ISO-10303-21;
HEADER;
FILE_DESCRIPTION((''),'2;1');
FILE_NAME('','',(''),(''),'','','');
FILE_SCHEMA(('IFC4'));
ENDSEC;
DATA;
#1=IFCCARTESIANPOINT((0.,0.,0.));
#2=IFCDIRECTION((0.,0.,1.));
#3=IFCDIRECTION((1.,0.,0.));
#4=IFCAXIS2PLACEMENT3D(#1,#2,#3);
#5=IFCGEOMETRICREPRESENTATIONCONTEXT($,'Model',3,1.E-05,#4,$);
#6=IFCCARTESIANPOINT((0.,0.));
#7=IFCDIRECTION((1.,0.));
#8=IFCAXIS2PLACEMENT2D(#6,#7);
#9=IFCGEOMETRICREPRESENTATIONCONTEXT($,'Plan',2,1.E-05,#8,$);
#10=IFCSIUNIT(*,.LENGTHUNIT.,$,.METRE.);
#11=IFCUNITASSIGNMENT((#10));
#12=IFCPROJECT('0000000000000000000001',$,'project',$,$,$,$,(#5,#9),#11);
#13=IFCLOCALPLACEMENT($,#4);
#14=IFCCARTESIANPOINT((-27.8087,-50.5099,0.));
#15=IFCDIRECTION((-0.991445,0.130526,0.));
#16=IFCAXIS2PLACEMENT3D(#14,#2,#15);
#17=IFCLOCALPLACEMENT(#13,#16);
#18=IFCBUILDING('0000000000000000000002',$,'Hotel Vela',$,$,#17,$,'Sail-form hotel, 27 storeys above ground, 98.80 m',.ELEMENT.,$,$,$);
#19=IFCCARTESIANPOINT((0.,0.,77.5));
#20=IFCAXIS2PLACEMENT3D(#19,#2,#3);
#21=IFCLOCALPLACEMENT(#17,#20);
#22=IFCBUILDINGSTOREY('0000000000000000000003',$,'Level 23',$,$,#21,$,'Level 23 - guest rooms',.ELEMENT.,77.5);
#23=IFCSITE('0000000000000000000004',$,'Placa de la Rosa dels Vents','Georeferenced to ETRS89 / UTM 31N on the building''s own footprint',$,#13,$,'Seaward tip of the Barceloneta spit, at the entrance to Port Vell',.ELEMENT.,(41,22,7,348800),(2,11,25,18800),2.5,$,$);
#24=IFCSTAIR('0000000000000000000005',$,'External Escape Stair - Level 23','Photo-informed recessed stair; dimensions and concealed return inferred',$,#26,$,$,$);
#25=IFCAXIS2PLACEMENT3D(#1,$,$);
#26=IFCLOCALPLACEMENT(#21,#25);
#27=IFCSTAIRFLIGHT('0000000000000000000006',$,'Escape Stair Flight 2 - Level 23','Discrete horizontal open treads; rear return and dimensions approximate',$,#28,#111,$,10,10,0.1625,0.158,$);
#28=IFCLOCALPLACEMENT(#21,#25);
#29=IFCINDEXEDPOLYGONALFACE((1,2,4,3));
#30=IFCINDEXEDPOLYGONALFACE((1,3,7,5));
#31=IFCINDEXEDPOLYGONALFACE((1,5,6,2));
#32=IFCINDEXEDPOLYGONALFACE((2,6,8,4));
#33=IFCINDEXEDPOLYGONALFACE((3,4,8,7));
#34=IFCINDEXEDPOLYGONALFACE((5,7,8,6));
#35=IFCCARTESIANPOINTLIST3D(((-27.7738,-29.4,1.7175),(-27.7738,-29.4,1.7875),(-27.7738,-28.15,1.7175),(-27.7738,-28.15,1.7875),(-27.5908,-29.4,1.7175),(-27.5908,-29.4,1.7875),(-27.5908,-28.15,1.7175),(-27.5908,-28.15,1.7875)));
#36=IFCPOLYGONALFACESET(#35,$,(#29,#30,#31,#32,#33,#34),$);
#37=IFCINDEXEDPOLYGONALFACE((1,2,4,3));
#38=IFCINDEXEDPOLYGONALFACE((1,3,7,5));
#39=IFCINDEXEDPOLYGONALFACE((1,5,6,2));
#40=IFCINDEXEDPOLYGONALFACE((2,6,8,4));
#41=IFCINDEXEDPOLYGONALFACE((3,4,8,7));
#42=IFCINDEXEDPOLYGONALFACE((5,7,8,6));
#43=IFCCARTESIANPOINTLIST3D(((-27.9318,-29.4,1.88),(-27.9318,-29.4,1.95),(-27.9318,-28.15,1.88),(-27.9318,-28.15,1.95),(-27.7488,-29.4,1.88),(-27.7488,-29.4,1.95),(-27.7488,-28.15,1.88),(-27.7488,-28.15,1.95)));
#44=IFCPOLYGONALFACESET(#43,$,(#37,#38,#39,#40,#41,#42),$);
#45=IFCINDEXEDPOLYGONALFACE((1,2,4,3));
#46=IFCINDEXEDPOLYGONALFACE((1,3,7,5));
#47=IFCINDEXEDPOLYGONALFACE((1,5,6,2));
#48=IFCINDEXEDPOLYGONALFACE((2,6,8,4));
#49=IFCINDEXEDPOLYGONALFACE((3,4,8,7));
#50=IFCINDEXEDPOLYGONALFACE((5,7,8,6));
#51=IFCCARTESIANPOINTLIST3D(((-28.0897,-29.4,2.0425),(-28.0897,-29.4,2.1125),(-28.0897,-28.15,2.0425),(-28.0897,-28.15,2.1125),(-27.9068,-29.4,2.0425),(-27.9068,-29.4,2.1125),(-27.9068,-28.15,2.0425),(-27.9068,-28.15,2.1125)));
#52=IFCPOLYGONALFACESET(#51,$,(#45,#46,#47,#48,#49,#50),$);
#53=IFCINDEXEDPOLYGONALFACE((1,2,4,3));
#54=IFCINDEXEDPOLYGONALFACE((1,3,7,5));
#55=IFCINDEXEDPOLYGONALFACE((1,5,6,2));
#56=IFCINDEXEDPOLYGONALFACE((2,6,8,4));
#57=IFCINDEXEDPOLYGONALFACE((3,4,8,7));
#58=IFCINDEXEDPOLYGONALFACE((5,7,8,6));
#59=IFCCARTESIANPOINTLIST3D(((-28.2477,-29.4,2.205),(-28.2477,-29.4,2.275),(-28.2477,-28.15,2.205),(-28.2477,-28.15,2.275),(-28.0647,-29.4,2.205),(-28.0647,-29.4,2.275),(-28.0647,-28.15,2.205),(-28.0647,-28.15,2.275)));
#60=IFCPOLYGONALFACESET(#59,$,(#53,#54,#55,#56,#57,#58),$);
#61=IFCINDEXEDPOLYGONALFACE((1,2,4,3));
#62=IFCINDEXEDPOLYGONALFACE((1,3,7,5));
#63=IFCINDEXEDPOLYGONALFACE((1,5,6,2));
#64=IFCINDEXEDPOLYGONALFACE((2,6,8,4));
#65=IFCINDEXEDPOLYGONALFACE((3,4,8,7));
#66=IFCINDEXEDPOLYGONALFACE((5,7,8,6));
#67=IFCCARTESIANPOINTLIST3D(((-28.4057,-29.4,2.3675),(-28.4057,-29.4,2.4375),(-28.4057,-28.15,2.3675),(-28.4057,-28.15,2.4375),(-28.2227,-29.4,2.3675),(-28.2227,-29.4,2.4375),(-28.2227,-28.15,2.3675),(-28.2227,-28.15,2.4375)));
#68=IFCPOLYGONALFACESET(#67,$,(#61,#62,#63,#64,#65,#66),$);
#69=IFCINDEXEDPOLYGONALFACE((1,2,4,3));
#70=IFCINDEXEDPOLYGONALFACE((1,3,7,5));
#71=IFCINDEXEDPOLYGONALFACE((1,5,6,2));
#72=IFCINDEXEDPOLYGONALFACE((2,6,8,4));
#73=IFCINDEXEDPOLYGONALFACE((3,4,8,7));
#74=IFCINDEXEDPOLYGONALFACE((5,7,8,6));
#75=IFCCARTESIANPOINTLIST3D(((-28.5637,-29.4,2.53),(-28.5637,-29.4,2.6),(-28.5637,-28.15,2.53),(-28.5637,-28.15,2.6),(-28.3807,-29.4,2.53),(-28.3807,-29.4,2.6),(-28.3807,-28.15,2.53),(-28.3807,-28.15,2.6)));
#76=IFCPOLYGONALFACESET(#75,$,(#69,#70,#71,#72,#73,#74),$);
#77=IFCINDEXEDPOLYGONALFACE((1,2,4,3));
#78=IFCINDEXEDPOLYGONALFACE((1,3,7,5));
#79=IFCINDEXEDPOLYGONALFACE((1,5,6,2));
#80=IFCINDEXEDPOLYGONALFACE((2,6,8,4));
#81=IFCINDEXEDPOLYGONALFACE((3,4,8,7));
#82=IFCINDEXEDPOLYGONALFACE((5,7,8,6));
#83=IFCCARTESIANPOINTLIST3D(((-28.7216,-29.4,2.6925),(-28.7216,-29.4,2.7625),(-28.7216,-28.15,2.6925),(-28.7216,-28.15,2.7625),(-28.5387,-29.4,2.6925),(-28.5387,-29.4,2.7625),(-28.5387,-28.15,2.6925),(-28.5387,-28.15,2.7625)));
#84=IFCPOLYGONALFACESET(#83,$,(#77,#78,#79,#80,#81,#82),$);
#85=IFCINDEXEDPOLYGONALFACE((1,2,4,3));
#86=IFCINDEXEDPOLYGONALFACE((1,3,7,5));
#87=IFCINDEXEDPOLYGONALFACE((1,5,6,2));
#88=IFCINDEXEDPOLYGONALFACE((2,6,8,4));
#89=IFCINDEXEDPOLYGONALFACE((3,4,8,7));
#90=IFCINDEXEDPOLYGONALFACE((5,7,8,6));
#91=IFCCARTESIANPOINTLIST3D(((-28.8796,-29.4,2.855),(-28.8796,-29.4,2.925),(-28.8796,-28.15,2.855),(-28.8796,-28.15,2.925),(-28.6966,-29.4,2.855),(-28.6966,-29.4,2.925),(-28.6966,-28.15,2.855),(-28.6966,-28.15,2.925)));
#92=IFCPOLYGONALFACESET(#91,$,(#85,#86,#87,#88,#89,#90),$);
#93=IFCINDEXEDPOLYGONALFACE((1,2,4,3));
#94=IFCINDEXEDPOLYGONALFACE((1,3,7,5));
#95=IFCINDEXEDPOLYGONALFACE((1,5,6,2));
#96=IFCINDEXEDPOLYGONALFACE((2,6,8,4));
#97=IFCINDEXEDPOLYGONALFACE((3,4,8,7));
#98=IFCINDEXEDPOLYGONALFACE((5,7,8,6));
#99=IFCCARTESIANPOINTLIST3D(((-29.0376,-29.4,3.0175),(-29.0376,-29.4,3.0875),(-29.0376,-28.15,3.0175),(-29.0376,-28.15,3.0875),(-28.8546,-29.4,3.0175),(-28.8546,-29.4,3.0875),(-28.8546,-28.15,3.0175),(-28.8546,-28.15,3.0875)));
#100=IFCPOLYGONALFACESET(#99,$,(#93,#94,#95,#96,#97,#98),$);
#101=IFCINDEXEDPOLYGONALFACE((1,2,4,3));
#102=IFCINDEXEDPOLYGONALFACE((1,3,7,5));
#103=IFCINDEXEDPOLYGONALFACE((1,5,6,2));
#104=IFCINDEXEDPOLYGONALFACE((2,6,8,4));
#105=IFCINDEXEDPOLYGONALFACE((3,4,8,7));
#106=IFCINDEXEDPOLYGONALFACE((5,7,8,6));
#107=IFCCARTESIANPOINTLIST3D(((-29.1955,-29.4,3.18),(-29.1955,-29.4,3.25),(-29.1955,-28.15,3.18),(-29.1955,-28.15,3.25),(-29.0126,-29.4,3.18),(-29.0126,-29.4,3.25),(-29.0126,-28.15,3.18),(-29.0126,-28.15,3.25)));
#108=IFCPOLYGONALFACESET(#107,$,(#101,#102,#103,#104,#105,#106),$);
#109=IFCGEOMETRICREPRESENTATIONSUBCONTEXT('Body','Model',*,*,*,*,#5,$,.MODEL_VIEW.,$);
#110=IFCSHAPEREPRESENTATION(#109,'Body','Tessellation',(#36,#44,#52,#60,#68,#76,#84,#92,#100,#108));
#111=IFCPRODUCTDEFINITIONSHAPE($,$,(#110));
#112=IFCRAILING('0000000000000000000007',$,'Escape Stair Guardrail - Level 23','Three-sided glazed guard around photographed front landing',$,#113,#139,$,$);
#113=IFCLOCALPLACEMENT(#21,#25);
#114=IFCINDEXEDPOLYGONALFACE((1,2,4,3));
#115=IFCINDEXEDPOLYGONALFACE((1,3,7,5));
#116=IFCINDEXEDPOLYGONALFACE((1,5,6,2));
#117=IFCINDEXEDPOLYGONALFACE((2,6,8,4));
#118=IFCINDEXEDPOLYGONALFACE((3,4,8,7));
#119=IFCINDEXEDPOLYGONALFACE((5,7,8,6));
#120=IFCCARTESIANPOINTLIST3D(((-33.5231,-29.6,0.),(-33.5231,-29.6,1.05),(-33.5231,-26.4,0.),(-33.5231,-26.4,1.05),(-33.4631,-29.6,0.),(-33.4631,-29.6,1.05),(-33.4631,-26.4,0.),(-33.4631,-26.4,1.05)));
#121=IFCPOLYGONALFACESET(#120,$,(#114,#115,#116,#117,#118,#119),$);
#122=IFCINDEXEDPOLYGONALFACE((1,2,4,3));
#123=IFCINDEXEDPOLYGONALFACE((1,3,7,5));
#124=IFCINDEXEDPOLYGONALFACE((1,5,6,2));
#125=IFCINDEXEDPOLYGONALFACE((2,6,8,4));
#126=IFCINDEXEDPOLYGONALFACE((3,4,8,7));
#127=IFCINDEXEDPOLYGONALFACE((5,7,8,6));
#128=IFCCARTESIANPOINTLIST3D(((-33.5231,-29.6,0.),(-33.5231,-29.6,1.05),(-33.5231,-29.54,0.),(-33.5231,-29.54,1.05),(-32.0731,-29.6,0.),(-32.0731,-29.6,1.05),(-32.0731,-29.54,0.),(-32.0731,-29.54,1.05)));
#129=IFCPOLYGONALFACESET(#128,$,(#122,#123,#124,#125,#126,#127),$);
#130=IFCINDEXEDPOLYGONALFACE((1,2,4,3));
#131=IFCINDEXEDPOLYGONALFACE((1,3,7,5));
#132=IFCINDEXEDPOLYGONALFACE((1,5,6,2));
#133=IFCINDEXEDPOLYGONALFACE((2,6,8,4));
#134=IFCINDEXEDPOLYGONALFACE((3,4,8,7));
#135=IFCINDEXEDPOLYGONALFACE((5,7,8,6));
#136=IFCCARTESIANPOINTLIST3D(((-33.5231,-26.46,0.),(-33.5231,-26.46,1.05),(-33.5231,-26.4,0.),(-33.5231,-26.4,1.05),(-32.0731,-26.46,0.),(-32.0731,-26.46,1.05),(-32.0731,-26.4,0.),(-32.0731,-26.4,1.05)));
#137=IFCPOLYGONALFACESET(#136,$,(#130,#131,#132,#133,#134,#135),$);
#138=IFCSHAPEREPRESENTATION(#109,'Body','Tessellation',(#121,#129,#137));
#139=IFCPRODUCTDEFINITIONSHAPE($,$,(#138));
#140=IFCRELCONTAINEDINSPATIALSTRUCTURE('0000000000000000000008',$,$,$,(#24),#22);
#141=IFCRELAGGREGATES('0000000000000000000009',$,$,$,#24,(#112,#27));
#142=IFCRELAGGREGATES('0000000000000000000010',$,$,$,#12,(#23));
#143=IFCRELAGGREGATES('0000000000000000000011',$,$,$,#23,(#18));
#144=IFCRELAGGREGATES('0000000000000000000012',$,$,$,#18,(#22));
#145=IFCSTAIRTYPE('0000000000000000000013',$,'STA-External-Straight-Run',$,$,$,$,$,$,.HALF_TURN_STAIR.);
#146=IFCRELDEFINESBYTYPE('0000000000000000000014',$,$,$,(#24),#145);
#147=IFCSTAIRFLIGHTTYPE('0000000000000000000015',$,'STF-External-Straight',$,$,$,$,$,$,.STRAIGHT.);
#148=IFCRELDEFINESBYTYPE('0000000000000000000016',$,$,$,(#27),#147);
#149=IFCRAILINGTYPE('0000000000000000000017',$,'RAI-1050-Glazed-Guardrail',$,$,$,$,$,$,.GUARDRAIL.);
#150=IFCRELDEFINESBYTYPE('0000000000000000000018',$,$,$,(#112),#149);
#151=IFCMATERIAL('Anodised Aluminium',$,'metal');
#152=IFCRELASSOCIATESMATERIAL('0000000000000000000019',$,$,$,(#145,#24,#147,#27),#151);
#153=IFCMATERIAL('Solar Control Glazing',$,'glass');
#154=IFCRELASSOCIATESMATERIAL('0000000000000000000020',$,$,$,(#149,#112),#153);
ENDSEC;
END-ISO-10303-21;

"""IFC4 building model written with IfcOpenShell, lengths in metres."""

from ifc_helpers import new_model, si_unit, frame, origin_with_axes, origin_2d_with_axis, place, context, subcontext, project, spatial, line, indexed_curve, outline, extrude, material, type_object, element, aggregate, save


model = new_model("IFC4")

# Units and contexts
model_context = context("Model", 3, precision=1e-05, world=origin_with_axes())
plan_context = context("Plan", 2, precision=1e-05, world=origin_2d_with_axis())
body_context = subcontext(model_context, "Body", "Model", "MODEL_VIEW")
ifc_project = project(units=[si_unit("LENGTHUNIT", "METRE")], contexts=[model_context, plan_context])

# Site, building, storey
site_placement = place(None, origin_with_axes())
site = spatial("IfcSite", under=ifc_project, at=site_placement, Name="Placa de la Rosa dels Vents", Description="Georeferenced to ETRS89 / UTM 31N on the building's own footprint", LongName="Seaward tip of the Barceloneta spit, at the entrance to Port Vell", CompositionType="ELEMENT", RefLatitude=(41, 22, 7, 348800), RefLongitude=(2, 11, 25, 18800), RefElevation=2.5)
building_placement = place(site_placement, frame((-27.8087, -50.5099, 0.0), z_axis=(0.0, 0.0, 1.0), x_axis=(-0.991445, 0.130526, 0.0)))
building = spatial("IfcBuilding", under=site, at=building_placement, Name="Hotel Vela", LongName="Sail-form hotel, 27 storeys above ground, 98.80 m", CompositionType="ELEMENT")
storey_placement = place(building_placement, frame((0.0, 0.0, 77.5), z_axis=(0.0, 0.0, 1.0), x_axis=(1.0, 0.0, 0.0)))
storey = spatial("IfcBuildingStorey", under=building, at=storey_placement, Name="Level 23", LongName="Level 23 - guest rooms", CompositionType="ELEMENT", Elevation=77.5)

# Stair
ifc_material_1 = material(Name="Anodised Aluminium", Category="metal")
stair_type = type_object("IfcStairType", Name="STA-External-Straight-Run", PredefinedType="HALF_TURN_STAIR", material=ifc_material_1)
stair_placement = place(storey_placement, frame((0.0, 0.0, -77.5), z_axis=(0.0, 0.0, 1.0), x_axis=(1.0, 0.0, 0.0)))
stair = element("IfcStair", 1, at=stair_placement, inside=storey, type_object=stair_type, material=ifc_material_1, Name="External Escape Stair - Level 23", Description="Photo-informed recessed stair; dimensions and concealed return inferred")

# Stair flight
stair_flight_type = type_object("IfcStairFlightType", Name="STF-External-Straight", PredefinedType="STRAIGHT", material=ifc_material_1)
stair_flight_1_placement = place(stair_placement, origin_with_axes())
stair_flight_1 = element("IfcStairFlight", 2, at=stair_flight_1_placement, type_object=stair_flight_type, material=ifc_material_1, Name="Escape Stair Flight 2 - Level 23", Description="Discrete horizontal open treads; rear return and dimensions approximate", NumberOfRisers=10, NumberOfTreads=10, RiserHeight=0.1625, TreadLength=0.158, context=body_context, shape_type="SweptSolid", body=[
    extrude(outline(indexed_curve([(0.0, 0.0), (0.183, 0.0), (0.183, 1.25), (0.0, 1.25)], segments=[line(1, 2, 3, 4, 1)])), frame((-27.7738, -29.4, 79.2175), z_axis=(0.0, 0.0, 1.0), x_axis=(1.0, 0.0, 0.0)), (0.0, 0.0, 1.0), 0.07),
    extrude(outline(indexed_curve([(0.0, 0.0), (0.183, 0.0), (0.183, 1.25), (0.0, 1.25)], segments=[line(1, 2, 3, 4, 1)])), frame((-27.9318, -29.4, 79.38), z_axis=(0.0, 0.0, 1.0), x_axis=(1.0, 0.0, 0.0)), (0.0, 0.0, 1.0), 0.07),
    extrude(outline(indexed_curve([(0.0, 0.0), (0.183, 0.0), (0.183, 1.25), (0.0, 1.25)], segments=[line(1, 2, 3, 4, 1)])), frame((-28.0897, -29.4, 79.5425), z_axis=(0.0, 0.0, 1.0), x_axis=(1.0, 0.0, 0.0)), (0.0, 0.0, 1.0), 0.07),
    extrude(outline(indexed_curve([(0.0, 0.0), (0.183, 0.0), (0.183, 1.25), (0.0, 1.25)], segments=[line(1, 2, 3, 4, 1)])), frame((-28.2477, -29.4, 79.705), z_axis=(0.0, 0.0, 1.0), x_axis=(1.0, 0.0, 0.0)), (0.0, 0.0, 1.0), 0.07),
    extrude(outline(indexed_curve([(0.0, 0.0), (0.183, 0.0), (0.183, 1.25), (0.0, 1.25)], segments=[line(1, 2, 3, 4, 1)])), frame((-28.4057, -29.4, 79.8675), z_axis=(0.0, 0.0, 1.0), x_axis=(1.0, 0.0, 0.0)), (0.0, 0.0, 1.0), 0.07),
    extrude(outline(indexed_curve([(0.0, 0.0), (0.183, 0.0), (0.183, 1.25), (0.0, 1.25)], segments=[line(1, 2, 3, 4, 1)])), frame((-28.5637, -29.4, 80.03), z_axis=(0.0, 0.0, 1.0), x_axis=(1.0, 0.0, 0.0)), (0.0, 0.0, 1.0), 0.07),
    extrude(outline(indexed_curve([(0.0, 0.0), (0.183, 0.0), (0.183, 1.25), (0.0, 1.25)], segments=[line(1, 2, 3, 4, 1)])), frame((-28.7216, -29.4, 80.1925), z_axis=(0.0, 0.0, 1.0), x_axis=(1.0, 0.0, 0.0)), (0.0, 0.0, 1.0), 0.07),
    extrude(outline(indexed_curve([(0.0, 0.0), (0.183, 0.0), (0.183, 1.25), (0.0, 1.25)], segments=[line(1, 2, 3, 4, 1)])), frame((-28.8796, -29.4, 80.355), z_axis=(0.0, 0.0, 1.0), x_axis=(1.0, 0.0, 0.0)), (0.0, 0.0, 1.0), 0.07),
    extrude(outline(indexed_curve([(0.0, 0.0), (0.183, 0.0), (0.183, 1.25), (0.0, 1.25)], segments=[line(1, 2, 3, 4, 1)])), frame((-29.0376, -29.4, 80.5175), z_axis=(0.0, 0.0, 1.0), x_axis=(1.0, 0.0, 0.0)), (0.0, 0.0, 1.0), 0.07),
    extrude(outline(indexed_curve([(0.0, 0.0), (0.183, 0.0), (0.183, 1.25), (0.0, 1.25)], segments=[line(1, 2, 3, 4, 1)])), frame((-29.1955, -29.4, 80.68), z_axis=(0.0, 0.0, 1.0), x_axis=(1.0, 0.0, 0.0)), (0.0, 0.0, 1.0), 0.07),
])

# Railing
ifc_material_2 = material(Name="Solar Control Glazing", Category="glass")
railing_type = type_object("IfcRailingType", Name="RAI-1050-Glazed-Guardrail", PredefinedType="GUARDRAIL", material=ifc_material_2)
railing_placement = place(stair_placement, origin_with_axes())
railing = element("IfcRailing", 3, at=railing_placement, type_object=railing_type, material=ifc_material_2, Name="Escape Stair Guardrail - Level 23", Description="Three-sided glazed guard around photographed front landing", context=body_context, shape_type="SweptSolid", body=[
    extrude(outline(indexed_curve([(0.0, 0.0), (0.06, 0.0), (0.06, 3.2), (0.0, 3.2)], segments=[line(1, 2, 3, 4, 1)])), frame((-33.5231, -29.6, 77.5), z_axis=(0.0, 0.0, 1.0), x_axis=(1.0, 0.0, 0.0)), (0.0, 0.0, 1.0), 1.05),
    extrude(outline(indexed_curve([(0.0, 0.0), (1.45, 0.0), (1.45, 0.06), (0.0, 0.06)], segments=[line(1, 2, 3, 4, 1)])), frame((-33.5231, -29.6, 77.5), z_axis=(0.0, 0.0, 1.0), x_axis=(1.0, 0.0, 0.0)), (0.0, 0.0, 1.0), 1.05),
    extrude(outline(indexed_curve([(0.0, 0.0), (1.45, 0.0), (1.45, 0.06), (0.0, 0.06)], segments=[line(1, 2, 3, 4, 1)])), frame((-33.5231, -26.46, 77.5), z_axis=(0.0, 0.0, 1.0), x_axis=(1.0, 0.0, 0.0)), (0.0, 0.0, 1.0), 1.05),
])
aggregate(stair, [railing, stair_flight_1])

save(model, "model.ifc")
